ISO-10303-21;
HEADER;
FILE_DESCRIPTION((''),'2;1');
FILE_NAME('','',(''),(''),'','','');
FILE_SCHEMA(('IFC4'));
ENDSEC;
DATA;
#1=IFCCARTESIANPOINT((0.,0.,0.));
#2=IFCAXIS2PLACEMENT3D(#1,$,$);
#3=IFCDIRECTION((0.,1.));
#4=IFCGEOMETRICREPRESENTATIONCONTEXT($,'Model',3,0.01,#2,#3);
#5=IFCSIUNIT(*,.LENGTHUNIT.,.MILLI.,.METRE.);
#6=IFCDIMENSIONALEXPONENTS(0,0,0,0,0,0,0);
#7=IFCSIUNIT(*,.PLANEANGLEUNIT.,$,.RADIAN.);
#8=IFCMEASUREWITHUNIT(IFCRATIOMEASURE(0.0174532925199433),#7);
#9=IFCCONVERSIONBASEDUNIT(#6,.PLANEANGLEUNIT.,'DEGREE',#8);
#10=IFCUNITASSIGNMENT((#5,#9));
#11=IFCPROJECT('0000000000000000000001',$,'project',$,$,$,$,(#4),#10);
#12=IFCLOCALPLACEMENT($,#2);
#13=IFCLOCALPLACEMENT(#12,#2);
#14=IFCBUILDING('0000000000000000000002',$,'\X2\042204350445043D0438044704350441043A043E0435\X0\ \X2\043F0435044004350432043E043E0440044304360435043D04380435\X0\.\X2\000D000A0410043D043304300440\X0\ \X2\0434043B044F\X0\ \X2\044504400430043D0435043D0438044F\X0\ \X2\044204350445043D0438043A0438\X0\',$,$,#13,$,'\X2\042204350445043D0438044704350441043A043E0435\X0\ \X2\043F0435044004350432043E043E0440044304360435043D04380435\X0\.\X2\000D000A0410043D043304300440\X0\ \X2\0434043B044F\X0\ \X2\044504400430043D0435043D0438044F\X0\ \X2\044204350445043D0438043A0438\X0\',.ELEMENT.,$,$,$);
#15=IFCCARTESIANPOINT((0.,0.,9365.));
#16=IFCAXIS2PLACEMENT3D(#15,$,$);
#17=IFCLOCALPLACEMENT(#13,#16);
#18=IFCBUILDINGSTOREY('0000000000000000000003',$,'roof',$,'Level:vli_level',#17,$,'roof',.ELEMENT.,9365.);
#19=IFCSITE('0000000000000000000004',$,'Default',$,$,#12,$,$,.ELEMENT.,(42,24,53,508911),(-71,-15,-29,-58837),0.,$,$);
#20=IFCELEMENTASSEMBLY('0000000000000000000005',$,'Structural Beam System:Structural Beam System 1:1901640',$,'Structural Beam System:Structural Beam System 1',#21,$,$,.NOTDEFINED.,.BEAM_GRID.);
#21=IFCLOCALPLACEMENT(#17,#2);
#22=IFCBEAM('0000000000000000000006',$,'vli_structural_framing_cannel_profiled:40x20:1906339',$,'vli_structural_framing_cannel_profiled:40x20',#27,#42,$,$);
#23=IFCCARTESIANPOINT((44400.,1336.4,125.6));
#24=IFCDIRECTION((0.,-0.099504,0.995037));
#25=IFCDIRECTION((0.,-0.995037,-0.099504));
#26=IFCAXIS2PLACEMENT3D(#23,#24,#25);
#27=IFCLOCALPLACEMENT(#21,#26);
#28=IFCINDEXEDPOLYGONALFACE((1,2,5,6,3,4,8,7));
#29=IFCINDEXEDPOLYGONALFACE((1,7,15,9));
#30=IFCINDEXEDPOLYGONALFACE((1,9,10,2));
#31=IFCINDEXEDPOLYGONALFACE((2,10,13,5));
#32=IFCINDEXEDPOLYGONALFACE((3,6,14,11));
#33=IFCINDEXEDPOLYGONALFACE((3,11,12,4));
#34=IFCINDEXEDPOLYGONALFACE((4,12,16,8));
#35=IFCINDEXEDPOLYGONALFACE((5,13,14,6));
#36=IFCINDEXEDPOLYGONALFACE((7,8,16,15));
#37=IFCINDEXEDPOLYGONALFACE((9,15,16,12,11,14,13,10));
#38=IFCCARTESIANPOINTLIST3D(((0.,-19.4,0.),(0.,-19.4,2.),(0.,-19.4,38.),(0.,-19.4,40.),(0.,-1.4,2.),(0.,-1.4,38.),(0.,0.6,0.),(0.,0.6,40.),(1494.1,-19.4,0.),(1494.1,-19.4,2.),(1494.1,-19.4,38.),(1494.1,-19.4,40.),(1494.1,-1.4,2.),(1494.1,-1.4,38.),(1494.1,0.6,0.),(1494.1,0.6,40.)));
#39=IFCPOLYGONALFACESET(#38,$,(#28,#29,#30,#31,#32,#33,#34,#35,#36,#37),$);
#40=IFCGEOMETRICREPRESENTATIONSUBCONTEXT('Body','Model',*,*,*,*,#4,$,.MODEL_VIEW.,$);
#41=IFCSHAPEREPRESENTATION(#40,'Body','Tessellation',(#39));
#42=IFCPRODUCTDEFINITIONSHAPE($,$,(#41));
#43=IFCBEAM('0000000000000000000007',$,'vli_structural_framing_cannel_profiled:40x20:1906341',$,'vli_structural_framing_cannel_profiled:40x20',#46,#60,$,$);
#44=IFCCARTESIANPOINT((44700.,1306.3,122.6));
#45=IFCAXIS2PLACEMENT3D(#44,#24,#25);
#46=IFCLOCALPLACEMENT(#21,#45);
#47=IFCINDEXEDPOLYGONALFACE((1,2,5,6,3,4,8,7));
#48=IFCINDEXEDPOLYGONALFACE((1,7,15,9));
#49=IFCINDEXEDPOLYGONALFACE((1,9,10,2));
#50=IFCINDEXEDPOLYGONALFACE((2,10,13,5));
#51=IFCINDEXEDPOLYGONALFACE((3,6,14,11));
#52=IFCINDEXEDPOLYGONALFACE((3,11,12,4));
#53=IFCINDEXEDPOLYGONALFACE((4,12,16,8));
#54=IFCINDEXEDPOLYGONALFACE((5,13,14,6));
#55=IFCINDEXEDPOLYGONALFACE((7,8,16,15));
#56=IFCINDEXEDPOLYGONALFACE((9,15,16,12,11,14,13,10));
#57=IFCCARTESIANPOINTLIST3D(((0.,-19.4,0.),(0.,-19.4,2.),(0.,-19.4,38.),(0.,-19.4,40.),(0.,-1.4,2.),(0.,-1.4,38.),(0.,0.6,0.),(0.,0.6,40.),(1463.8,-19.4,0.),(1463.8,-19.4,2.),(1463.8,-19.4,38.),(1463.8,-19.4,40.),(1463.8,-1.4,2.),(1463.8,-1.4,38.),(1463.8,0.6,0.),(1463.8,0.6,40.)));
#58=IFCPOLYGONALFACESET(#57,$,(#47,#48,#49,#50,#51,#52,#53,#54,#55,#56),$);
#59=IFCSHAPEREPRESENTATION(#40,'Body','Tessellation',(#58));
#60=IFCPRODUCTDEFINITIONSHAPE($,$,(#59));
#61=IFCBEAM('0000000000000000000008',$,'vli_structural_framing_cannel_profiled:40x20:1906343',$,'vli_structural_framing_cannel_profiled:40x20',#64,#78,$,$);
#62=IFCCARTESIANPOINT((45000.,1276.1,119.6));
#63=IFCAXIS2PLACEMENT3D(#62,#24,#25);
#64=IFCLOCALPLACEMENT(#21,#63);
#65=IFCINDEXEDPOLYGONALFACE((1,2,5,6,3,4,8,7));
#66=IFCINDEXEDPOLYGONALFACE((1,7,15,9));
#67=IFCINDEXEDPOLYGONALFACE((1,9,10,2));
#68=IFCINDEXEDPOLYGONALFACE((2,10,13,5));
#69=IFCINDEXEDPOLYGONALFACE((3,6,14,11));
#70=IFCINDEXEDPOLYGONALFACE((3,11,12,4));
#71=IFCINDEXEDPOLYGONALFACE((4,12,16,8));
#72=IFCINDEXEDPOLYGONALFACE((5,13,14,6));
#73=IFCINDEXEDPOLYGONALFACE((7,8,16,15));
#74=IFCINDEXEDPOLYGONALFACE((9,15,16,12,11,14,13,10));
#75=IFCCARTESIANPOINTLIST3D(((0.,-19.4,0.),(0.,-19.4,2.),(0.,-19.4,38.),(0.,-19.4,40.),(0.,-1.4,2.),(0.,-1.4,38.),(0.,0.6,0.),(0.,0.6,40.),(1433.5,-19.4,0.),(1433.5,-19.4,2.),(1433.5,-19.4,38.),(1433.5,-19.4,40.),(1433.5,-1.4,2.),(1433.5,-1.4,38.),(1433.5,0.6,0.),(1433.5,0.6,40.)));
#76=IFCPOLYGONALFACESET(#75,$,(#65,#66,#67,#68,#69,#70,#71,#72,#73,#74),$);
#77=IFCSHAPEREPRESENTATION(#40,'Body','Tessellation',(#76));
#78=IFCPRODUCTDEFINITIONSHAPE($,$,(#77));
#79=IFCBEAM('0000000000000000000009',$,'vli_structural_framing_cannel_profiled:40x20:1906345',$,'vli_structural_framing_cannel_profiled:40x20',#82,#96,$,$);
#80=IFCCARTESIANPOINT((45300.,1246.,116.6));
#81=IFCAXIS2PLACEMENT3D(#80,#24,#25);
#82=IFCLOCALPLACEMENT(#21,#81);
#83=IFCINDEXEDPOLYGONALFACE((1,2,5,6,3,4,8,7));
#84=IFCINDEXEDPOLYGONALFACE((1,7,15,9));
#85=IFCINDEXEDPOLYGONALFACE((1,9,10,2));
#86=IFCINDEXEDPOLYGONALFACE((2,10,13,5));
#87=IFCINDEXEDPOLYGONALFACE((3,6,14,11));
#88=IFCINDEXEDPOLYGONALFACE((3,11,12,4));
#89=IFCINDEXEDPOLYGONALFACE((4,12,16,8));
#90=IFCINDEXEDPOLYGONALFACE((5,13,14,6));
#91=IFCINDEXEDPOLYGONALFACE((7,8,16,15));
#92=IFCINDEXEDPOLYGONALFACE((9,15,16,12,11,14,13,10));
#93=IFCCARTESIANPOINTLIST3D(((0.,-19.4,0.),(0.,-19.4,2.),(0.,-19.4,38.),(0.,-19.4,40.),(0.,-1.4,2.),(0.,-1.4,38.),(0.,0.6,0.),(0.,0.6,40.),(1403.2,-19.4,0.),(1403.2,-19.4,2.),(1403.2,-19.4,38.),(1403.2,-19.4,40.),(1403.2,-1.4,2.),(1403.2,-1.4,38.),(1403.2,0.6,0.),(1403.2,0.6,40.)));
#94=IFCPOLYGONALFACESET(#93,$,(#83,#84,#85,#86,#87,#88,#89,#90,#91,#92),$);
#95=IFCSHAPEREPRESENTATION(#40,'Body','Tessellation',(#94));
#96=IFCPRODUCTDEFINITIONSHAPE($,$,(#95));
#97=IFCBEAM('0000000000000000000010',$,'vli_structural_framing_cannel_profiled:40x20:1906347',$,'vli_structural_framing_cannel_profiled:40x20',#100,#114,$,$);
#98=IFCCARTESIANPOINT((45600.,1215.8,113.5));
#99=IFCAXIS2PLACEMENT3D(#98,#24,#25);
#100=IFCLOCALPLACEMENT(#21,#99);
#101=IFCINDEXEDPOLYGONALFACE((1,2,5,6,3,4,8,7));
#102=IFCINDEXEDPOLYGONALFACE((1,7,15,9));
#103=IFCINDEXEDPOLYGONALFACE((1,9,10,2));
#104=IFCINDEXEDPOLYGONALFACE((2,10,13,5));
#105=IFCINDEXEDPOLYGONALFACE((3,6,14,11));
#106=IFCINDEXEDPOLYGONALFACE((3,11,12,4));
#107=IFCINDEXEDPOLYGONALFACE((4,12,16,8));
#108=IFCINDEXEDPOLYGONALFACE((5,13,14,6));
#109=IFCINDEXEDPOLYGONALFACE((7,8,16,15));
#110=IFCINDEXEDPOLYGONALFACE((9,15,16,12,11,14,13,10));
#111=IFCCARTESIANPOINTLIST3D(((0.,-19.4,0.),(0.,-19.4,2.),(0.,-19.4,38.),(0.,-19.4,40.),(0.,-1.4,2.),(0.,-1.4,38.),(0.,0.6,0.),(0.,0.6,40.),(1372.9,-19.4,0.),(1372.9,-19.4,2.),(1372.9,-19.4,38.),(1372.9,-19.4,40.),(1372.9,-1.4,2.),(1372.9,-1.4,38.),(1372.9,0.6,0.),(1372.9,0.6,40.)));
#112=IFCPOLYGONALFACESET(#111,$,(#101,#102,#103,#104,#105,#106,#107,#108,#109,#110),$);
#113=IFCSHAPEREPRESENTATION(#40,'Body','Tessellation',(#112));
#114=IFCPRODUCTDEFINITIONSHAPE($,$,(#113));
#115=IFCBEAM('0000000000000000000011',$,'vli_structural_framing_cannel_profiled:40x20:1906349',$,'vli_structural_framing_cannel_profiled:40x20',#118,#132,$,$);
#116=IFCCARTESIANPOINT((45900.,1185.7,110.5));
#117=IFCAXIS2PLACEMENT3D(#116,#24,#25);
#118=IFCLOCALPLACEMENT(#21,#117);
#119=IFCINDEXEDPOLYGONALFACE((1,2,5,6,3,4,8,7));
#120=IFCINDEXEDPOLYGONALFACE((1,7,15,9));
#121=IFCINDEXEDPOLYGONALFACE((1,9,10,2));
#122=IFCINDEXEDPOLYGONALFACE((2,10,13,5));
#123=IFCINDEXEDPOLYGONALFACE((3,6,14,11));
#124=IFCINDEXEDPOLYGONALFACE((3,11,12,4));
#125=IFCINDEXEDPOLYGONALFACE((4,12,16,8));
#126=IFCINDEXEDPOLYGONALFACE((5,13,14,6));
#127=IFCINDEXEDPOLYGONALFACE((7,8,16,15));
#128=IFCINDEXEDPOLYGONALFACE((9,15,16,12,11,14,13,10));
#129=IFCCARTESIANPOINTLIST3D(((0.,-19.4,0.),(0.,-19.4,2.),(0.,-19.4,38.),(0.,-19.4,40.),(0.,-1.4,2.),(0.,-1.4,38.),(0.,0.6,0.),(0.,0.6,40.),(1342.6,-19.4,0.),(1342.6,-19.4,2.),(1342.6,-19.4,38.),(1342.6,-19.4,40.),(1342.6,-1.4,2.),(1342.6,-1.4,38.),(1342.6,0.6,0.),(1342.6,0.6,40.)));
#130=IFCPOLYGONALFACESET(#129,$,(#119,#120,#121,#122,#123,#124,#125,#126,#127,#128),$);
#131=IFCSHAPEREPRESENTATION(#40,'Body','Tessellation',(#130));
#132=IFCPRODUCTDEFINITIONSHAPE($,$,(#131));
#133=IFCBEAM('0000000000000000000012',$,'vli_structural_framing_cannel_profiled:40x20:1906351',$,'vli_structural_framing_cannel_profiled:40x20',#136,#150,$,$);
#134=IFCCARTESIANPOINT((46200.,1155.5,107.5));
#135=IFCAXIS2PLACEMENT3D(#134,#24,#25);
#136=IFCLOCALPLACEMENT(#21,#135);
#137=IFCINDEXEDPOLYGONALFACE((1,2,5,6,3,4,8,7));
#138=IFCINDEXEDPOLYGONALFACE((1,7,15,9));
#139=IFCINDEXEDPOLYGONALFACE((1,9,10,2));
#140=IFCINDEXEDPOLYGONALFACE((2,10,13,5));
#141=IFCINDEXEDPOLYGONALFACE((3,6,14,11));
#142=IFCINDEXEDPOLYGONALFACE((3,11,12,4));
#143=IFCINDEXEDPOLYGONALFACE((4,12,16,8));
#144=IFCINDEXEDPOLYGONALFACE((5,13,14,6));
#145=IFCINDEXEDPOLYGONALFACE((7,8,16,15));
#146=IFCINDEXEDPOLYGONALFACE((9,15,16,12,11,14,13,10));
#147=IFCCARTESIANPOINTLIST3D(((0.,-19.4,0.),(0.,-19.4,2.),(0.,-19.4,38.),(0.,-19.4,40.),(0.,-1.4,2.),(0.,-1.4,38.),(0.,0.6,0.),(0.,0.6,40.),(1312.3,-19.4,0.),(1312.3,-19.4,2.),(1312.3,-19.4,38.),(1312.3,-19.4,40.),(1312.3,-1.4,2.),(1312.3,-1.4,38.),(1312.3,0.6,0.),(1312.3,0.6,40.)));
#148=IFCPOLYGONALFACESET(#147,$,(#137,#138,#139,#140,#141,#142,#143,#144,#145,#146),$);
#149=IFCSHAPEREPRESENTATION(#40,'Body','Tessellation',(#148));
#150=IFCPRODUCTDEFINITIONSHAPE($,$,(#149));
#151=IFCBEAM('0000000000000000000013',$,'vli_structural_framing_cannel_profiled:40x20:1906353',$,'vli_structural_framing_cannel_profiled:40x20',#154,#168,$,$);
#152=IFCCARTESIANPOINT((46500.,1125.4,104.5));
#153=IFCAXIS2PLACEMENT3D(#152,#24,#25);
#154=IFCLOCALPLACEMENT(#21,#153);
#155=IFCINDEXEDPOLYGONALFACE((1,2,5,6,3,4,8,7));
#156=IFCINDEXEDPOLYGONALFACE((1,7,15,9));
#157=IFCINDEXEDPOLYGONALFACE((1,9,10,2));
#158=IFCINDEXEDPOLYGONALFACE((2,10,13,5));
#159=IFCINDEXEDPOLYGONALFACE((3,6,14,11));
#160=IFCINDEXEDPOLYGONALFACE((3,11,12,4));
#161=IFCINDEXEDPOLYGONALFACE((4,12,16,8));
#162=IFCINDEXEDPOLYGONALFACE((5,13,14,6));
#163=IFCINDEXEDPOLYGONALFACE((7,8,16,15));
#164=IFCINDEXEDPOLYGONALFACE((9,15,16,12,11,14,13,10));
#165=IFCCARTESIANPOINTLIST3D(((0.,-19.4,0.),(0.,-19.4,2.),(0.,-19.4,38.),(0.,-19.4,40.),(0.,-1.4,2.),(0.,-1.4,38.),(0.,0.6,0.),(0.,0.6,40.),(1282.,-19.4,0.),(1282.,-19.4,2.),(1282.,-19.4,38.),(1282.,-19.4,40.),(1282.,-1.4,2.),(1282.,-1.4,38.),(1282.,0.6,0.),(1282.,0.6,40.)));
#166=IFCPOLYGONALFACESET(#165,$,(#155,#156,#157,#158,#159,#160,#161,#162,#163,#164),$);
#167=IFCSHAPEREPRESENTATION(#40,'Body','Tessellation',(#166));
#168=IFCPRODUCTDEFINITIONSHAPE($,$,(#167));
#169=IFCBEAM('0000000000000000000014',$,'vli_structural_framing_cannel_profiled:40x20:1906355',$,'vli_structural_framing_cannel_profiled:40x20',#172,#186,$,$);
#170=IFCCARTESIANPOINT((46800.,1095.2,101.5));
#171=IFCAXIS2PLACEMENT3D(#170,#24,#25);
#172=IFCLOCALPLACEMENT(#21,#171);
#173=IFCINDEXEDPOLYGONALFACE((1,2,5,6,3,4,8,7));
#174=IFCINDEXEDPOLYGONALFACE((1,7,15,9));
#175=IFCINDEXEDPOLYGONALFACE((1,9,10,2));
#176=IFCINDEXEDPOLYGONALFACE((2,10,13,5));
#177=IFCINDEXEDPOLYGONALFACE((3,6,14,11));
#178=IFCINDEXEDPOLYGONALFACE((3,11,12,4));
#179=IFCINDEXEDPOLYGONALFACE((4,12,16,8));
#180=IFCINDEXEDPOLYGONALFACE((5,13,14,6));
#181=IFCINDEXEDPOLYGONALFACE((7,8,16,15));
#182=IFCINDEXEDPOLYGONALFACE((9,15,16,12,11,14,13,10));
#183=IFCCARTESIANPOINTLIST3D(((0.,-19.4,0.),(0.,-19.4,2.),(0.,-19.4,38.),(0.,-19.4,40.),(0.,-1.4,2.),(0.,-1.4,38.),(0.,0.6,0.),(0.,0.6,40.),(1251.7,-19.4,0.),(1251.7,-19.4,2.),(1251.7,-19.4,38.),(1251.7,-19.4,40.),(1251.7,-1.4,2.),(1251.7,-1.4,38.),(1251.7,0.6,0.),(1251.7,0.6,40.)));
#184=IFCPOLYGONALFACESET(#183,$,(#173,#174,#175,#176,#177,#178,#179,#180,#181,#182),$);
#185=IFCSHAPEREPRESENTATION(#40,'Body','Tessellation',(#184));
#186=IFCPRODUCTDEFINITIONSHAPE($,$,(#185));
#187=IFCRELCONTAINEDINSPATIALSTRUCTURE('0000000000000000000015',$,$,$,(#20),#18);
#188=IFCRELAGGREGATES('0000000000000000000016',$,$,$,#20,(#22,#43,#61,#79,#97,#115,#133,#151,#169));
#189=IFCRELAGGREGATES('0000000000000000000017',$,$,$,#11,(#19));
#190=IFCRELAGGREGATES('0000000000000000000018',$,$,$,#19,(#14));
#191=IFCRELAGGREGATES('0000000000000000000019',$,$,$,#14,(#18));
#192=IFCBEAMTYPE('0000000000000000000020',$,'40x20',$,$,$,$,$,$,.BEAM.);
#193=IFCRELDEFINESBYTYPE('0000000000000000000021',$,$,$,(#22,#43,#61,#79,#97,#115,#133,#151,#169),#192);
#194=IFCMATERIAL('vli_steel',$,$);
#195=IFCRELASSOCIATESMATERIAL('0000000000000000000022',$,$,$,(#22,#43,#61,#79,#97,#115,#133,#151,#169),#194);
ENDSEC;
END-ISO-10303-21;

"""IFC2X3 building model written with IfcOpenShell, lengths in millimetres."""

from ifc_helpers import new_model, entity, si_unit, converted_unit, direction, frame, origin, place, context, subcontext, project, spatial, polyline, outline, extrude, material, type_object, element, aggregate, save


model = new_model("IFC2X3")

# Units and contexts
model_context = context("Model", 3, precision=0.01, world=origin(), true_north=direction((0.0, 1.0)))
body_context = subcontext(model_context, "Body", "Model", "MODEL_VIEW")
ifc_project = project(units=[si_unit("LENGTHUNIT", "METRE", prefix="MILLI"), converted_unit("PLANEANGLEUNIT", "DEGREE", entity("IfcRatioMeasure", 0.0174532925199433), si_unit("PLANEANGLEUNIT", "RADIAN"), dimensions=[0, 0, 0, 0, 0, 0, 0])], contexts=[model_context])

# Site, building, storey
site_placement = place(None, origin())
site = spatial("IfcSite", under=ifc_project, at=site_placement, Name="Default", CompositionType="ELEMENT", RefLatitude=(42, 24, 53, 508911), RefLongitude=(-71, -15, -29, -58837), RefElevation=0.0)
building_placement = place(site_placement, origin())
building = spatial("IfcBuilding", under=site, at=building_placement, Name="Техническое перевооружение.\r\nАнгар для хранения техники", LongName="Техническое перевооружение.\r\nАнгар для хранения техники", CompositionType="ELEMENT")
storey_placement = place(building_placement, frame((0.0, 0.0, 9365.0)))
storey = spatial("IfcBuildingStorey", under=building, at=storey_placement, Name="roof", ObjectType="Level:vli_level", LongName="roof", CompositionType="ELEMENT", Elevation=9365.0)

# Element assembly, beams
assembly_1_placement = place(storey_placement, origin())
assembly_1 = element("IfcElementAssembly", 1, at=assembly_1_placement, inside=storey, Name="Structural Beam System:Structural Beam System 1:1901640", ObjectType="Structural Beam System:Structural Beam System 1", AssemblyPlace="NOTDEFINED", PredefinedType="BEAM_GRID")
ifc_material = material(Name="vli_steel")
beam_type = type_object("IfcBeamType", Name="40x20", PredefinedType="BEAM")
beam_1_placement = place(assembly_1_placement, frame((44400.0, 1336.4, 125.6), z_axis=(0.0, -0.099504, 0.995037), x_axis=(0.0, -0.995037, -0.099504)))
beam_1 = element("IfcBeam", 2, at=beam_1_placement, type_object=beam_type, material=ifc_material, Name="vli_structural_framing_cannel_profiled:40x20:1906339", ObjectType="vli_structural_framing_cannel_profiled:40x20", context=body_context, shape_type="SweptSolid", body=[
    extrude(outline(polyline([(-20.0, -9.5), (-18.0, -9.5), (-18.0, 8.5), (18.0, 8.5), (18.0, -9.5), (20.0, -9.5), (20.0, 10.5), (-20.0, 10.5), (-20.0, -9.5)])), frame((0.0, -9.9, 20.0), z_axis=(1.0, 0.0, 0.0), x_axis=(0.0, 0.0, -1.0)), (0.0, 0.0, 1.0), 1494.1),
])
beam_2_placement = place(assembly_1_placement, frame((44700.0, 1306.3, 122.6), z_axis=(0.0, -0.099504, 0.995037), x_axis=(0.0, -0.995037, -0.099504)))
beam_2 = element("IfcBeam", 3, at=beam_2_placement, type_object=beam_type, material=ifc_material, Name="vli_structural_framing_cannel_profiled:40x20:1906341", ObjectType="vli_structural_framing_cannel_profiled:40x20", context=body_context, shape_type="SweptSolid", body=[
    extrude(outline(polyline([(-20.0, -9.5), (-18.0, -9.5), (-18.0, 8.5), (18.0, 8.5), (18.0, -9.5), (20.0, -9.5), (20.0, 10.5), (-20.0, 10.5), (-20.0, -9.5)])), frame((0.0, -9.9, 20.0), z_axis=(1.0, 0.0, 0.0), x_axis=(0.0, 0.0, -1.0)), (0.0, 0.0, 1.0), 1463.8),
])
beam_3_placement = place(assembly_1_placement, frame((45000.0, 1276.1, 119.6), z_axis=(0.0, -0.099504, 0.995037), x_axis=(0.0, -0.995037, -0.099504)))
beam_3 = element("IfcBeam", 4, at=beam_3_placement, type_object=beam_type, material=ifc_material, Name="vli_structural_framing_cannel_profiled:40x20:1906343", ObjectType="vli_structural_framing_cannel_profiled:40x20", context=body_context, shape_type="SweptSolid", body=[
    extrude(outline(polyline([(-20.0, -9.5), (-18.0, -9.5), (-18.0, 8.5), (18.0, 8.5), (18.0, -9.5), (20.0, -9.5), (20.0, 10.5), (-20.0, 10.5), (-20.0, -9.5)])), frame((0.0, -9.9, 20.0), z_axis=(1.0, 0.0, 0.0), x_axis=(0.0, 0.0, -1.0)), (0.0, 0.0, 1.0), 1433.5),
])
beam_4_placement = place(assembly_1_placement, frame((45300.0, 1246.0, 116.6), z_axis=(0.0, -0.099504, 0.995037), x_axis=(0.0, -0.995037, -0.099504)))
beam_4 = element("IfcBeam", 5, at=beam_4_placement, type_object=beam_type, material=ifc_material, Name="vli_structural_framing_cannel_profiled:40x20:1906345", ObjectType="vli_structural_framing_cannel_profiled:40x20", context=body_context, shape_type="SweptSolid", body=[
    extrude(outline(polyline([(-20.0, -9.5), (-18.0, -9.5), (-18.0, 8.5), (18.0, 8.5), (18.0, -9.5), (20.0, -9.5), (20.0, 10.5), (-20.0, 10.5), (-20.0, -9.5)])), frame((0.0, -9.9, 20.0), z_axis=(1.0, 0.0, 0.0), x_axis=(0.0, 0.0, -1.0)), (0.0, 0.0, 1.0), 1403.2),
])
beam_5_placement = place(assembly_1_placement, frame((45600.0, 1215.8, 113.5), z_axis=(0.0, -0.099504, 0.995037), x_axis=(0.0, -0.995037, -0.099504)))
beam_5 = element("IfcBeam", 6, at=beam_5_placement, type_object=beam_type, material=ifc_material, Name="vli_structural_framing_cannel_profiled:40x20:1906347", ObjectType="vli_structural_framing_cannel_profiled:40x20", context=body_context, shape_type="SweptSolid", body=[
    extrude(outline(polyline([(-20.0, -9.5), (-18.0, -9.5), (-18.0, 8.5), (18.0, 8.5), (18.0, -9.5), (20.0, -9.5), (20.0, 10.5), (-20.0, 10.5), (-20.0, -9.5)])), frame((0.0, -9.9, 20.0), z_axis=(1.0, 0.0, 0.0), x_axis=(0.0, 0.0, -1.0)), (0.0, 0.0, 1.0), 1372.9),
])
beam_6_placement = place(assembly_1_placement, frame((45900.0, 1185.7, 110.5), z_axis=(0.0, -0.099504, 0.995037), x_axis=(0.0, -0.995037, -0.099504)))
beam_6 = element("IfcBeam", 7, at=beam_6_placement, type_object=beam_type, material=ifc_material, Name="vli_structural_framing_cannel_profiled:40x20:1906349", ObjectType="vli_structural_framing_cannel_profiled:40x20", context=body_context, shape_type="SweptSolid", body=[
    extrude(outline(polyline([(-20.0, -9.5), (-18.0, -9.5), (-18.0, 8.5), (18.0, 8.5), (18.0, -9.5), (20.0, -9.5), (20.0, 10.5), (-20.0, 10.5), (-20.0, -9.5)])), frame((0.0, -9.9, 20.0), z_axis=(1.0, 0.0, 0.0), x_axis=(0.0, 0.0, -1.0)), (0.0, 0.0, 1.0), 1342.6),
])
beam_7_placement = place(assembly_1_placement, frame((46200.0, 1155.5, 107.5), z_axis=(0.0, -0.099504, 0.995037), x_axis=(0.0, -0.995037, -0.099504)))
beam_7 = element("IfcBeam", 8, at=beam_7_placement, type_object=beam_type, material=ifc_material, Name="vli_structural_framing_cannel_profiled:40x20:1906351", ObjectType="vli_structural_framing_cannel_profiled:40x20", context=body_context, shape_type="SweptSolid", body=[
    extrude(outline(polyline([(-20.0, -9.5), (-18.0, -9.5), (-18.0, 8.5), (18.0, 8.5), (18.0, -9.5), (20.0, -9.5), (20.0, 10.5), (-20.0, 10.5), (-20.0, -9.5)])), frame((0.0, -9.9, 20.0), z_axis=(1.0, 0.0, 0.0), x_axis=(0.0, 0.0, -1.0)), (0.0, 0.0, 1.0), 1312.3),
])
beam_8_placement = place(assembly_1_placement, frame((46500.0, 1125.4, 104.5), z_axis=(0.0, -0.099504, 0.995037), x_axis=(0.0, -0.995037, -0.099504)))
beam_8 = element("IfcBeam", 9, at=beam_8_placement, type_object=beam_type, material=ifc_material, Name="vli_structural_framing_cannel_profiled:40x20:1906353", ObjectType="vli_structural_framing_cannel_profiled:40x20", context=body_context, shape_type="SweptSolid", body=[
    extrude(outline(polyline([(-20.0, -9.5), (-18.0, -9.5), (-18.0, 8.5), (18.0, 8.5), (18.0, -9.5), (20.0, -9.5), (20.0, 10.5), (-20.0, 10.5), (-20.0, -9.5)])), frame((0.0, -9.9, 20.0), z_axis=(1.0, 0.0, 0.0), x_axis=(0.0, 0.0, -1.0)), (0.0, 0.0, 1.0), 1282.0),
])
beam_9_placement = place(assembly_1_placement, frame((46800.0, 1095.2, 101.5), z_axis=(0.0, -0.099504, 0.995037), x_axis=(0.0, -0.995037, -0.099504)))
beam_9 = element("IfcBeam", 10, at=beam_9_placement, type_object=beam_type, material=ifc_material, Name="vli_structural_framing_cannel_profiled:40x20:1906355", ObjectType="vli_structural_framing_cannel_profiled:40x20", context=body_context, shape_type="SweptSolid", body=[
    extrude(outline(polyline([(-20.0, -9.5), (-18.0, -9.5), (-18.0, 8.5), (18.0, 8.5), (18.0, -9.5), (20.0, -9.5), (20.0, 10.5), (-20.0, 10.5), (-20.0, -9.5)])), frame((0.0, -9.9, 20.0), z_axis=(1.0, 0.0, 0.0), x_axis=(0.0, 0.0, -1.0)), (0.0, 0.0, 1.0), 1251.7),
])
aggregate(assembly_1, [beam_1, beam_2, beam_3, beam_4, beam_5, beam_6, beam_7, beam_8, beam_9])

save(model, "model.ifc")
